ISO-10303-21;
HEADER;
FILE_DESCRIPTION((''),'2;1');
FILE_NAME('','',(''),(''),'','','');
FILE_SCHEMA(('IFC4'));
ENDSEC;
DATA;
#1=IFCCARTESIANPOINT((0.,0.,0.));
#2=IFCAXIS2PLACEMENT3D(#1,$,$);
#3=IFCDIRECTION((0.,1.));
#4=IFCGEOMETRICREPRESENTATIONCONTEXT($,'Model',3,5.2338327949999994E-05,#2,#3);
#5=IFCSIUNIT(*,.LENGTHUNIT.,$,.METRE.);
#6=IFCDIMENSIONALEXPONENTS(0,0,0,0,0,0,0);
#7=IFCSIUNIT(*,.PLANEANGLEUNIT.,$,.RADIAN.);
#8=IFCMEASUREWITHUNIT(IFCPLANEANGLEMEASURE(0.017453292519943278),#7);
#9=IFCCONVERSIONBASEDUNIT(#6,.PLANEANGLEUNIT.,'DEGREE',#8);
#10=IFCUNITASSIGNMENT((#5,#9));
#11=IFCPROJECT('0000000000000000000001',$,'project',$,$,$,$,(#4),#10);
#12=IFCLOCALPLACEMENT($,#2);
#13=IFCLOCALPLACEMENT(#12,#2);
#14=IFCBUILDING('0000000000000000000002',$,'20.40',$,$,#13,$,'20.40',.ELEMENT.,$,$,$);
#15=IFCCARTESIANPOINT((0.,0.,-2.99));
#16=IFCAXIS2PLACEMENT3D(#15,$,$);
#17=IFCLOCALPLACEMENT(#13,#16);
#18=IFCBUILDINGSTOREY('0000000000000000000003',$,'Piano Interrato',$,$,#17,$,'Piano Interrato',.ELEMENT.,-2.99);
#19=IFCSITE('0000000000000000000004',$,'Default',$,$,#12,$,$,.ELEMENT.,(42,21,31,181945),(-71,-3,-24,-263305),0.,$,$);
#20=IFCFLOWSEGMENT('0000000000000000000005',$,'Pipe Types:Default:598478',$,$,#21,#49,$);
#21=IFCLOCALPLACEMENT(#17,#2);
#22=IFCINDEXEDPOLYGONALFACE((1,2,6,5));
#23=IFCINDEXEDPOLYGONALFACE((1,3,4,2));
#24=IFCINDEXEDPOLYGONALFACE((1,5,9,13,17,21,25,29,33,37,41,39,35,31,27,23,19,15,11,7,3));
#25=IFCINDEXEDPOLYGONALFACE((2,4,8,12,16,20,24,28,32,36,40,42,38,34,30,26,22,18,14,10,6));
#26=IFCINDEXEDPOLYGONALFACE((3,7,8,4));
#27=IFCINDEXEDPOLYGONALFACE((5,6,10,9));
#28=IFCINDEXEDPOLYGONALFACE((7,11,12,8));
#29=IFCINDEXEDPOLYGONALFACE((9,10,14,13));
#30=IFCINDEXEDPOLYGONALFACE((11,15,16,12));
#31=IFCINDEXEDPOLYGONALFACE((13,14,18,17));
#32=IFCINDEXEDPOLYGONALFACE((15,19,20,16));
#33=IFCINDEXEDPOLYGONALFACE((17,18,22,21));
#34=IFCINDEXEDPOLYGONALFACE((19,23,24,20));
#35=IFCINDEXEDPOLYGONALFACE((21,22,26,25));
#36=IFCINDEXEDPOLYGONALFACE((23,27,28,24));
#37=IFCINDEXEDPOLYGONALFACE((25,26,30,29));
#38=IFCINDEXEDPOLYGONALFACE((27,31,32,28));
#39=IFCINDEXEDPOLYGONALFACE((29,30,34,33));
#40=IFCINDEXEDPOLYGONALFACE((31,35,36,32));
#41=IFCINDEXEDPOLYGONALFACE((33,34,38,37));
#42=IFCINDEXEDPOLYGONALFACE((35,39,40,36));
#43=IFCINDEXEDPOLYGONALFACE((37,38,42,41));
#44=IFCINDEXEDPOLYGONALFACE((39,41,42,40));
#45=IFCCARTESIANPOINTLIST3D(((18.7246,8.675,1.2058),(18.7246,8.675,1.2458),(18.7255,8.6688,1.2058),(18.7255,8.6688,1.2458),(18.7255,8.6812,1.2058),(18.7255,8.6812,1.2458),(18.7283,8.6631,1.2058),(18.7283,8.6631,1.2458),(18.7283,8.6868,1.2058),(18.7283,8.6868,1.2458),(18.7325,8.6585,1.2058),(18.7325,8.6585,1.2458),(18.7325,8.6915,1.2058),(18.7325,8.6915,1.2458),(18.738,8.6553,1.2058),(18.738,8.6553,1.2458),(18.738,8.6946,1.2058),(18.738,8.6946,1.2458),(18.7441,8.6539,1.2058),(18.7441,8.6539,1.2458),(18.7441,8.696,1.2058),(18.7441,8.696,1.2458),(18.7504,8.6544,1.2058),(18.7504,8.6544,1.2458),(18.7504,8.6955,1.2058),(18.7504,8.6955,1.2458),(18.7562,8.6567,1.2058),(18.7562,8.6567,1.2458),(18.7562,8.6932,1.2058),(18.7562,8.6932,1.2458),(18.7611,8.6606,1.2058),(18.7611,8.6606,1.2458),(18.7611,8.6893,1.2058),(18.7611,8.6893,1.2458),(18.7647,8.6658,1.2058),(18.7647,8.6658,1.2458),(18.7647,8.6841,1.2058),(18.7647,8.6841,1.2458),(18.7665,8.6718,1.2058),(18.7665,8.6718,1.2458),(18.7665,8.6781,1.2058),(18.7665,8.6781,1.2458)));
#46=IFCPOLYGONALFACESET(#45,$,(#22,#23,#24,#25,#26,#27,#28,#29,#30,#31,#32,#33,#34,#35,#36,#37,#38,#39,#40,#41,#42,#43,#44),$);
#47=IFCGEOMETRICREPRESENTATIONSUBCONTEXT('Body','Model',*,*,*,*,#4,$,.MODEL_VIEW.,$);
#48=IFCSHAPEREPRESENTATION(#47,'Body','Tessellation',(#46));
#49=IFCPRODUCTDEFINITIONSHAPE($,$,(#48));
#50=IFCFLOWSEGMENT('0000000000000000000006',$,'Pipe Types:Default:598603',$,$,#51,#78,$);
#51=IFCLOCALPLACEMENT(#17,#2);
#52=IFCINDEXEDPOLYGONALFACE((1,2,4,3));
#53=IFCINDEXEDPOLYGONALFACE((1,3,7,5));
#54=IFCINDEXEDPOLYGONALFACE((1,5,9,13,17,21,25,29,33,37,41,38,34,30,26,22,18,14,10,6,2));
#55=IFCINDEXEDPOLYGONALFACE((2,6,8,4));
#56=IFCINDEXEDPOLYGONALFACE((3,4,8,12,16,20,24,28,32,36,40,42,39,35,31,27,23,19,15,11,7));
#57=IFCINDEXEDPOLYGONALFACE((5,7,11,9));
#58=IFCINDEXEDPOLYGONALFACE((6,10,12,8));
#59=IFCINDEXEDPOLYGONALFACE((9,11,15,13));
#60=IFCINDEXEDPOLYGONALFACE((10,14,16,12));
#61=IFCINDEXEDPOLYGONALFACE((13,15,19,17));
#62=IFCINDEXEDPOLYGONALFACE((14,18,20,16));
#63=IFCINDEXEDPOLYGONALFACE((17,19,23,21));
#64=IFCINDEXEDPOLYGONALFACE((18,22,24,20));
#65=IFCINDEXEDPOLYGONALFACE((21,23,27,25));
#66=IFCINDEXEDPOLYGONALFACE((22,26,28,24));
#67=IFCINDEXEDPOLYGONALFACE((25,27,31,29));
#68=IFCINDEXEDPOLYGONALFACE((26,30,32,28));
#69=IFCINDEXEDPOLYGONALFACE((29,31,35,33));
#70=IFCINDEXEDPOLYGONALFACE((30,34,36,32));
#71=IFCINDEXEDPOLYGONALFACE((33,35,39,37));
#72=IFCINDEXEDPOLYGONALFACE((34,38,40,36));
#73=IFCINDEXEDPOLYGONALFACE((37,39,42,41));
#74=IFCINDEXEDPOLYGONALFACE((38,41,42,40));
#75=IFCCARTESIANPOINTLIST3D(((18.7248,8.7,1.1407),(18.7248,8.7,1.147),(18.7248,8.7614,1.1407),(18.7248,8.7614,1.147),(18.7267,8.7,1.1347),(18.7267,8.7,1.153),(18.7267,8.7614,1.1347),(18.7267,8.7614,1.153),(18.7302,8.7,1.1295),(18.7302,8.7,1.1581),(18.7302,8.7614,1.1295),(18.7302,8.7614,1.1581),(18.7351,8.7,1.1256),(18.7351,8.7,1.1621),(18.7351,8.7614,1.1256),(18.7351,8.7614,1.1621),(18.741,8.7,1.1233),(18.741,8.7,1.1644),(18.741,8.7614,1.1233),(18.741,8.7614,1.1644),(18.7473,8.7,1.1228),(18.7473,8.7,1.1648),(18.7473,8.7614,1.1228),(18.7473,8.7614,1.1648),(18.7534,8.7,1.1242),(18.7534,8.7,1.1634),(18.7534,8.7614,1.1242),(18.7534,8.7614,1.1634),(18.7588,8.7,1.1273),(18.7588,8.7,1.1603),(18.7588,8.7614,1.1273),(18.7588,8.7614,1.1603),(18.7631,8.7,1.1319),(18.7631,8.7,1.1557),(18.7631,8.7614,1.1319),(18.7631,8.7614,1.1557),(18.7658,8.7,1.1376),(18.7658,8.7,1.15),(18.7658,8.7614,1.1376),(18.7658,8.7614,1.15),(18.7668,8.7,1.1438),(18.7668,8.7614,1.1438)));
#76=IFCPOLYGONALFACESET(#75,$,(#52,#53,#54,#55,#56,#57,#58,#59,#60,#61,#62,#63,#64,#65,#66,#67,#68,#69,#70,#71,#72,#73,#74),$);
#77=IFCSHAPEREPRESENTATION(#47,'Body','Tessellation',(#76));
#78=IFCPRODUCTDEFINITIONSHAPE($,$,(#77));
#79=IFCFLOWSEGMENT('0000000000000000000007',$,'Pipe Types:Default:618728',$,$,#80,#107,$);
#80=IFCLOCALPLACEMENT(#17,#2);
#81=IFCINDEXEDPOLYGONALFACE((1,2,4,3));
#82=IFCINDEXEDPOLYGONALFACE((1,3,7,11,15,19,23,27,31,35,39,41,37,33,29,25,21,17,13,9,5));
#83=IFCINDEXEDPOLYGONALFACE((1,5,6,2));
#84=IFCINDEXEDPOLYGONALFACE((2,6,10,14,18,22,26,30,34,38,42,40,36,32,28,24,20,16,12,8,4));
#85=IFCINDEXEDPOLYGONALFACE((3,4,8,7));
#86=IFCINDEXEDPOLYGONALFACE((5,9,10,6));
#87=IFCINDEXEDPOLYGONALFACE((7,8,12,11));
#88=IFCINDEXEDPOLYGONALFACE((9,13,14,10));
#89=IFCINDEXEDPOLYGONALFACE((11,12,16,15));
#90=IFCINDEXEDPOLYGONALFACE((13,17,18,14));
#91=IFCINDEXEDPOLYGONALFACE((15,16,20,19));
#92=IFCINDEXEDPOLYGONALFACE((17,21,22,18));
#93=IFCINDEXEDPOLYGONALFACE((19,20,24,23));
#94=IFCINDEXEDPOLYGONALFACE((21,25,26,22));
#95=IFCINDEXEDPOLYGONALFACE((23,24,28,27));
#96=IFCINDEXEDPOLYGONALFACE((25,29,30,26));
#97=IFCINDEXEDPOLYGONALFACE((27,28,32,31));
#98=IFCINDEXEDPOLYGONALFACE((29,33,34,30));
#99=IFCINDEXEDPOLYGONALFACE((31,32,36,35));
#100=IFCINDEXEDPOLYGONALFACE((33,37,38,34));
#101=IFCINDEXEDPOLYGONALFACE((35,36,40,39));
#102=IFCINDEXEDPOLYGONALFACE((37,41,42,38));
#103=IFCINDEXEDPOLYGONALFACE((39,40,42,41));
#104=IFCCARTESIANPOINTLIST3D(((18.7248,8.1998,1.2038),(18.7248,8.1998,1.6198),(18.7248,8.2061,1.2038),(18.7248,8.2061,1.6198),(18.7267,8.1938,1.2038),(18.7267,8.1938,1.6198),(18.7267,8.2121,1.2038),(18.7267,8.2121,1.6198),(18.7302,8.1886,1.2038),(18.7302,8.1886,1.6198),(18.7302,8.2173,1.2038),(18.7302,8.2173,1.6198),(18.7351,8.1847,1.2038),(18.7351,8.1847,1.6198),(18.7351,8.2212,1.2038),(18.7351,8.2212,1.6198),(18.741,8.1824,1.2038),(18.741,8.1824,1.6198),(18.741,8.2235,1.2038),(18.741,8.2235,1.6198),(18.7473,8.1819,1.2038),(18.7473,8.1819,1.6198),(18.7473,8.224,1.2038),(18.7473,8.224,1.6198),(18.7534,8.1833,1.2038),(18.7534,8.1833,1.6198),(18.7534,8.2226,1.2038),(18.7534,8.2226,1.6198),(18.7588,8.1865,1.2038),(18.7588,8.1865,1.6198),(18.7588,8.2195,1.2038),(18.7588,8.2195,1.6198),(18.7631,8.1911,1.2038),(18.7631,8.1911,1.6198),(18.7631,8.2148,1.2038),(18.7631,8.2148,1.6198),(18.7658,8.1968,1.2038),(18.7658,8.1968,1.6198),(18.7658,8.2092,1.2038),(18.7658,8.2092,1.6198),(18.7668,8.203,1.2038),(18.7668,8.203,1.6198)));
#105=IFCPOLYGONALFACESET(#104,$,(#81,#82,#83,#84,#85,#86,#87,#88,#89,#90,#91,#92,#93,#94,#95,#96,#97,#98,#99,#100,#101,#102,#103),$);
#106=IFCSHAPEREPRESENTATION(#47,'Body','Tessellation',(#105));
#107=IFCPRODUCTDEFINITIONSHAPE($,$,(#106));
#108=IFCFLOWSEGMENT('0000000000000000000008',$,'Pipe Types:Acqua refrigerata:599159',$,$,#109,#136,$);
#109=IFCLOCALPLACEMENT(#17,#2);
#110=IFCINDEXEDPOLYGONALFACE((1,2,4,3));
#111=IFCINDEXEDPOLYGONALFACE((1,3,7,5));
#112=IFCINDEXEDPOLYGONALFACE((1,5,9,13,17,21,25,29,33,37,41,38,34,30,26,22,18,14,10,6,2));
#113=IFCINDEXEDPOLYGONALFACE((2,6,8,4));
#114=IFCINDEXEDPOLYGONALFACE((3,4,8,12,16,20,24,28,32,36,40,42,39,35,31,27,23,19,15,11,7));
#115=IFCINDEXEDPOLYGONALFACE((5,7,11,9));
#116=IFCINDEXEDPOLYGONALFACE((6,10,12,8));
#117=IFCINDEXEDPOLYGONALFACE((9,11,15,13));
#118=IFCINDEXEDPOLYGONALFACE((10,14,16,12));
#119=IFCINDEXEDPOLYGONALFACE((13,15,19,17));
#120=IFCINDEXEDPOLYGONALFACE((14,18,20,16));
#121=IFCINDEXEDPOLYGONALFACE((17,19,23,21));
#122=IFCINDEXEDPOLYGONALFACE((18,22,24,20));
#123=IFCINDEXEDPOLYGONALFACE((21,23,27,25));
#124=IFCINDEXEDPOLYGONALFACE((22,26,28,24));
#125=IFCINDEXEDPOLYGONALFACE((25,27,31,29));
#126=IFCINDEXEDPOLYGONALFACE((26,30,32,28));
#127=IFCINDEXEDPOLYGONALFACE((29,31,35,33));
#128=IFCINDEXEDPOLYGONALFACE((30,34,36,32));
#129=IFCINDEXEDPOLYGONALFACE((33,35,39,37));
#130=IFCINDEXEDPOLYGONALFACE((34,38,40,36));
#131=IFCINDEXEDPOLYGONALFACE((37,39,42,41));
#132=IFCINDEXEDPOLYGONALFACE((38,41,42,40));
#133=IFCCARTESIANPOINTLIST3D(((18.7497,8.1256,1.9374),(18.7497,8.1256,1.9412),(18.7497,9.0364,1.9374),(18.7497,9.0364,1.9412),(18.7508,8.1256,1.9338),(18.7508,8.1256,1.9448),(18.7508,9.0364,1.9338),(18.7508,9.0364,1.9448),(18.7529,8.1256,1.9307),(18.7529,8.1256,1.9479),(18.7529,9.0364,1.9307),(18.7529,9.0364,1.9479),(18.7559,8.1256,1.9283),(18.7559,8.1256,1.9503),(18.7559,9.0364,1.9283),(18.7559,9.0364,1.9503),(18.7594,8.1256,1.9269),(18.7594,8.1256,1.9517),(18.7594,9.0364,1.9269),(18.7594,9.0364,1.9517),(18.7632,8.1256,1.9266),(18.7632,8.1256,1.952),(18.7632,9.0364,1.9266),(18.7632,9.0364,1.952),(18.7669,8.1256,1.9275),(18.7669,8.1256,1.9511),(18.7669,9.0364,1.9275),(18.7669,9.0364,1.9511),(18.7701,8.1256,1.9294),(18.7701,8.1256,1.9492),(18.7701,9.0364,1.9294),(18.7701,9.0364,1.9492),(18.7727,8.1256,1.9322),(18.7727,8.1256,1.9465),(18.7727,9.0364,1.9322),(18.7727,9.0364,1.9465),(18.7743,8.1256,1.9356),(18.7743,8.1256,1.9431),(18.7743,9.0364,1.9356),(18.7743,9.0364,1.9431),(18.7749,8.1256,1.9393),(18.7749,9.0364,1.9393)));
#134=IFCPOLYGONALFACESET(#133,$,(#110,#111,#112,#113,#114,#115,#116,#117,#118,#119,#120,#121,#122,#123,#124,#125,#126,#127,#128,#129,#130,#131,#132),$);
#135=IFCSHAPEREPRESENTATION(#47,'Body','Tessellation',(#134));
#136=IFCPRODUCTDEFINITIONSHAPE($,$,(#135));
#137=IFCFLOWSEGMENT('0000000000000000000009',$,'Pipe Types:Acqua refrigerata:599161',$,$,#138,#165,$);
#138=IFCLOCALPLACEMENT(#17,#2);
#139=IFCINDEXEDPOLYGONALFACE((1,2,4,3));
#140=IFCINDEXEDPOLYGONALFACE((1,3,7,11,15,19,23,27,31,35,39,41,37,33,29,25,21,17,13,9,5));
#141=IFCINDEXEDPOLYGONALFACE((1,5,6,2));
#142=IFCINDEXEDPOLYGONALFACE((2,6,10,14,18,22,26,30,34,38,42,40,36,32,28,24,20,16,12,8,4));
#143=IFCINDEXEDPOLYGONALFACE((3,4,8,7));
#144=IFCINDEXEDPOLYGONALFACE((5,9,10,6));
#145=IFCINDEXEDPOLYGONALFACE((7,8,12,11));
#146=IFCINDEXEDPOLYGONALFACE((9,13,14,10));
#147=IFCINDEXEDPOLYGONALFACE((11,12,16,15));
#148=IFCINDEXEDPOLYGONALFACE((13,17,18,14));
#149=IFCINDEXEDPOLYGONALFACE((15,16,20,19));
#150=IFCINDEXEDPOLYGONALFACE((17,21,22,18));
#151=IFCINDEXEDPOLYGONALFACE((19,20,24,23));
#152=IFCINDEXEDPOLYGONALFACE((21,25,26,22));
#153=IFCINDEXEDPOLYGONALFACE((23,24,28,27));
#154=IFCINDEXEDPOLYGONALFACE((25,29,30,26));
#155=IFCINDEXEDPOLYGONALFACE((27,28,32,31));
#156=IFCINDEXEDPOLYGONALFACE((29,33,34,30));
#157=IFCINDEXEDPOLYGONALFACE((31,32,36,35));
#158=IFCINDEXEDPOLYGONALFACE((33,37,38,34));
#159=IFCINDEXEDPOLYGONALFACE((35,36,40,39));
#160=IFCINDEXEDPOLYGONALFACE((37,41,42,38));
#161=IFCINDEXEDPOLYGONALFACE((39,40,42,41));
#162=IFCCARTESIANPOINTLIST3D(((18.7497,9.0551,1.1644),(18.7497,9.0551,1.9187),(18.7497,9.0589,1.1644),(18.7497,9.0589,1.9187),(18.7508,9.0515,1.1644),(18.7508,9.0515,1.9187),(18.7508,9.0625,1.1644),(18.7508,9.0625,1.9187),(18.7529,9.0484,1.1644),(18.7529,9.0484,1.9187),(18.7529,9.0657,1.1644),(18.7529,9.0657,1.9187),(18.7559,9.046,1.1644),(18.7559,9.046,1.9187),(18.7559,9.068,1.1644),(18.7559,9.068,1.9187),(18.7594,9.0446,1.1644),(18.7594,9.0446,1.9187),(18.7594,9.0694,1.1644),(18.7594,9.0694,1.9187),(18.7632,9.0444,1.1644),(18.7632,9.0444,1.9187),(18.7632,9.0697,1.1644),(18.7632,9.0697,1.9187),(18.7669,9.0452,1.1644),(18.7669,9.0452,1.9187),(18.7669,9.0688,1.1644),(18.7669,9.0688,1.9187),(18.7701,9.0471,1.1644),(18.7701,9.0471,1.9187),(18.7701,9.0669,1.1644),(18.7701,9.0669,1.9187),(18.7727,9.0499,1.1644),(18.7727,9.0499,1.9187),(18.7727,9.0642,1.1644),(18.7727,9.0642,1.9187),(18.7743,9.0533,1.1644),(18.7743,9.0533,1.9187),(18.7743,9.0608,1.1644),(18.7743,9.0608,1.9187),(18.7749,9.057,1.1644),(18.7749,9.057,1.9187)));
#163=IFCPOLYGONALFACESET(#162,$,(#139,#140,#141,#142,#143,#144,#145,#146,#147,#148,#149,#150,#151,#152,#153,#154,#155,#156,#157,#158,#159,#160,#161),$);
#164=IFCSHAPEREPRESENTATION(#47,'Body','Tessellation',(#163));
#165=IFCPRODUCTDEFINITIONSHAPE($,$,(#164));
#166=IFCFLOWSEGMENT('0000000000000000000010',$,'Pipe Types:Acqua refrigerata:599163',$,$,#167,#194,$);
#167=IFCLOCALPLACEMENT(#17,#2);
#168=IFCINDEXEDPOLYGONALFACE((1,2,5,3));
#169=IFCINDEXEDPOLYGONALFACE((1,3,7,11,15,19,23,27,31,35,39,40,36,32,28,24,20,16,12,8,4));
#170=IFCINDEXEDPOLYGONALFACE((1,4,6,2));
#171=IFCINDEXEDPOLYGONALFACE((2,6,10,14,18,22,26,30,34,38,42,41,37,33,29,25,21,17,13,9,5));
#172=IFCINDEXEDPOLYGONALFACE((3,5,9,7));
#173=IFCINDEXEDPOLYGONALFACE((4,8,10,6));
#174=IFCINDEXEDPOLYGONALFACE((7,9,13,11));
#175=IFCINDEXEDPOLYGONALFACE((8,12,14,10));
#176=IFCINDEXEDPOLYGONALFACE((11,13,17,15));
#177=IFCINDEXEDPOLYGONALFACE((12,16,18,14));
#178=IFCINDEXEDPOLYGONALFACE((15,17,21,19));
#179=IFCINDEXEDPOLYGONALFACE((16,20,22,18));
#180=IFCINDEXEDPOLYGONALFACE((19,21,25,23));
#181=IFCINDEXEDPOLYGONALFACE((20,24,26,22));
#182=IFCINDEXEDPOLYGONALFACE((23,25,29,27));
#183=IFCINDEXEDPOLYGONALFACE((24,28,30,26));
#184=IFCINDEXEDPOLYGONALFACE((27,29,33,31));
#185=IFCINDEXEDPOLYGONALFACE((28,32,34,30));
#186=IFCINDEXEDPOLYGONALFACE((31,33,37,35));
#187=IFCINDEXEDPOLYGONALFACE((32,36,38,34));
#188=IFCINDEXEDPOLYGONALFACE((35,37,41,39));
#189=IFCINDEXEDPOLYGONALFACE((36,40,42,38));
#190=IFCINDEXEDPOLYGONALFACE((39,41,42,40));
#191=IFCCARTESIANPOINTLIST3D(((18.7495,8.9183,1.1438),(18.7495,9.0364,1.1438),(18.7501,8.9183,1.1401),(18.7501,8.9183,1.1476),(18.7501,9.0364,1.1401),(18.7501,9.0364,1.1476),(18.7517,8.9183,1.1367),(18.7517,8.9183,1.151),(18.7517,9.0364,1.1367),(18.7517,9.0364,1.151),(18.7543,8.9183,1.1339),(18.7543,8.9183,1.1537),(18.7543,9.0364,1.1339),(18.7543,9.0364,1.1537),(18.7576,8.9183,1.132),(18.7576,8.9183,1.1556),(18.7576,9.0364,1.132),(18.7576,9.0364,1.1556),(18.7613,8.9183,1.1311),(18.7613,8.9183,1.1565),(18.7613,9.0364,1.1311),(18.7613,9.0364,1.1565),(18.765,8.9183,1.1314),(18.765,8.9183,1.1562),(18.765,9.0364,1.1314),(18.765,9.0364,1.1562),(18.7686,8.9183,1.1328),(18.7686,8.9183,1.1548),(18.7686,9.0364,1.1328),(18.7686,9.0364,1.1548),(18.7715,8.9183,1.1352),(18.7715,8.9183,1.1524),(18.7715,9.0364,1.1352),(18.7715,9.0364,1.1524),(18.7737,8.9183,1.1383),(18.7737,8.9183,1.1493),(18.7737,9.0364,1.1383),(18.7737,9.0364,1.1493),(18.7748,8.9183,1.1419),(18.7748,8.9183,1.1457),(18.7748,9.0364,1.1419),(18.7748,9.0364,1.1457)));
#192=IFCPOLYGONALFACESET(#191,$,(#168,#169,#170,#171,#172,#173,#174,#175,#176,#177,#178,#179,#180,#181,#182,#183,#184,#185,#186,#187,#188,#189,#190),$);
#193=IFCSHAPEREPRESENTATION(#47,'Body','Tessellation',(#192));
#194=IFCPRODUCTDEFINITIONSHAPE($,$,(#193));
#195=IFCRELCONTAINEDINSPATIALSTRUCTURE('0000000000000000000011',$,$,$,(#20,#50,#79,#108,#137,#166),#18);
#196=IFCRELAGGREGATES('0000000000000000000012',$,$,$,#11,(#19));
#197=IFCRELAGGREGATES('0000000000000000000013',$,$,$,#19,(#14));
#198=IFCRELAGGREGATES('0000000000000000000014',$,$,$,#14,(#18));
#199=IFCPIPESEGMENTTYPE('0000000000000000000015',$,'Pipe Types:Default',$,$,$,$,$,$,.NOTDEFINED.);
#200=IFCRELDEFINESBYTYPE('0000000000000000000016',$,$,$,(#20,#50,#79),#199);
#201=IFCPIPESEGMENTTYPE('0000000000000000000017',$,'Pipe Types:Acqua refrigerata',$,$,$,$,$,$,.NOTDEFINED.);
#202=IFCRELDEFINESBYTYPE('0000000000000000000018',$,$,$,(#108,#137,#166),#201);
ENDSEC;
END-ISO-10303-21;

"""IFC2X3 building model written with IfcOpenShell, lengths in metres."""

from ifc_helpers import new_model, entity, si_unit, converted_unit, direction, frame, frame_2d, origin, origin_2d_with_axis, place, context, subcontext, project, spatial, circle, extrude, type_object, element, save


model = new_model("IFC2X3")

# Units and contexts
model_context = context("Model", 3, precision=5.2338327949999994e-05, world=origin(), true_north=direction((0.0, 1.0)))
body_context = subcontext(model_context, "Body", "Model", "MODEL_VIEW")
ifc_project = project(units=[si_unit("LENGTHUNIT", "METRE"), converted_unit("PLANEANGLEUNIT", "DEGREE", entity("IfcPlaneAngleMeasure", 0.017453292519943278), si_unit("PLANEANGLEUNIT", "RADIAN"), dimensions=[0, 0, 0, 0, 0, 0, 0])], contexts=[model_context])

# Site, building, storey
site_placement = place(None, origin())
site = spatial("IfcSite", under=ifc_project, at=site_placement, Name="Default", CompositionType="ELEMENT", RefLatitude=(42, 21, 31, 181945), RefLongitude=(-71, -3, -24, -263305), RefElevation=0.0)
building_placement = place(site_placement, origin())
building = spatial("IfcBuilding", under=site, at=building_placement, Name="20.40", LongName="20.40", CompositionType="ELEMENT")
storey_placement = place(building_placement, frame((0.0, 0.0, -2.99)))
storey = spatial("IfcBuildingStorey", under=building, at=storey_placement, Name="Piano Interrato", LongName="Piano Interrato", CompositionType="ELEMENT", Elevation=-2.99)

# Flow segments
pipe_segment_type_1 = type_object("IfcPipeSegmentType", Name="Pipe Types:Default", PredefinedType="NOTDEFINED")
flow_segment_1_placement = place(storey_placement, origin())
element("IfcFlowSegment", 1, at=flow_segment_1_placement, inside=storey, type_object=pipe_segment_type_1, Name="Pipe Types:Default:598478", context=body_context, shape_type="SweptSolid", body=[
    extrude(circle(Radius=0.0211, at=origin_2d_with_axis()), frame((18.7457, 8.675, 1.2058), z_axis=(0.0, 0.0, 1.0), x_axis=(-1.0, 0.0, 0.0)), (0.0, 0.0, 1.0), 0.04),
])
flow_segment_2_placement = place(storey_placement, origin())
element("IfcFlowSegment", 2, at=flow_segment_2_placement, inside=storey, type_object=pipe_segment_type_1, Name="Pipe Types:Default:598603", context=body_context, shape_type="SweptSolid", body=[
    extrude(circle(Radius=0.0211, at=origin_2d_with_axis()), frame((18.7457, 8.7, 1.1438), z_axis=(0.0, 1.0, 0.0), x_axis=(1.0, 0.0, 0.0)), (0.0, 0.0, 1.0), 0.0614),
])
flow_segment_3_placement = place(storey_placement, origin())
element("IfcFlowSegment", 3, at=flow_segment_3_placement, inside=storey, type_object=pipe_segment_type_1, Name="Pipe Types:Default:618728", context=body_context, shape_type="SweptSolid", body=[
    extrude(circle(Radius=0.0211, at=frame_2d((0.0, 0.0), x_axis=(1.0, 0.0))), frame((18.7457, 8.203, 1.2038)), (0.0, 0.0, 1.0), 0.416),
])
pipe_segment_type_2 = type_object("IfcPipeSegmentType", Name="Pipe Types:Acqua refrigerata", PredefinedType="NOTDEFINED")
flow_segment_4_placement = place(storey_placement, origin())
element("IfcFlowSegment", 4, at=flow_segment_4_placement, inside=storey, type_object=pipe_segment_type_2, Name="Pipe Types:Acqua refrigerata:599159", context=body_context, shape_type="SweptSolid", body=[
    extrude(circle(Radius=0.0127, at=frame_2d((0.0, 0.0), x_axis=(1.0, 0.0))), frame((18.7622, 8.1256, 1.9393), z_axis=(0.0, 1.0, 0.0), x_axis=(1.0, 0.0, 0.0)), (0.0, 0.0, 1.0), 0.9108),
])
flow_segment_5_placement = place(storey_placement, origin())
element("IfcFlowSegment", 5, at=flow_segment_5_placement, inside=storey, type_object=pipe_segment_type_2, Name="Pipe Types:Acqua refrigerata:599161", context=body_context, shape_type="SweptSolid", body=[
    extrude(circle(Radius=0.0127, at=frame_2d((0.0, 0.0), x_axis=(1.0, 0.0))), frame((18.7622, 9.057, 1.1644)), (0.0, 0.0, 1.0), 0.7542),
])
flow_segment_6_placement = place(storey_placement, origin())
element("IfcFlowSegment", 6, at=flow_segment_6_placement, inside=storey, type_object=pipe_segment_type_2, Name="Pipe Types:Acqua refrigerata:599163", context=body_context, shape_type="SweptSolid", body=[
    extrude(circle(Radius=0.0127, at=origin_2d_with_axis()), frame((18.7622, 8.9183, 1.1438), z_axis=(0.0, 1.0, 0.0), x_axis=(-1.0, 0.0, 0.0)), (0.0, 0.0, 1.0), 0.1181),
])

save(model, "model.ifc")
